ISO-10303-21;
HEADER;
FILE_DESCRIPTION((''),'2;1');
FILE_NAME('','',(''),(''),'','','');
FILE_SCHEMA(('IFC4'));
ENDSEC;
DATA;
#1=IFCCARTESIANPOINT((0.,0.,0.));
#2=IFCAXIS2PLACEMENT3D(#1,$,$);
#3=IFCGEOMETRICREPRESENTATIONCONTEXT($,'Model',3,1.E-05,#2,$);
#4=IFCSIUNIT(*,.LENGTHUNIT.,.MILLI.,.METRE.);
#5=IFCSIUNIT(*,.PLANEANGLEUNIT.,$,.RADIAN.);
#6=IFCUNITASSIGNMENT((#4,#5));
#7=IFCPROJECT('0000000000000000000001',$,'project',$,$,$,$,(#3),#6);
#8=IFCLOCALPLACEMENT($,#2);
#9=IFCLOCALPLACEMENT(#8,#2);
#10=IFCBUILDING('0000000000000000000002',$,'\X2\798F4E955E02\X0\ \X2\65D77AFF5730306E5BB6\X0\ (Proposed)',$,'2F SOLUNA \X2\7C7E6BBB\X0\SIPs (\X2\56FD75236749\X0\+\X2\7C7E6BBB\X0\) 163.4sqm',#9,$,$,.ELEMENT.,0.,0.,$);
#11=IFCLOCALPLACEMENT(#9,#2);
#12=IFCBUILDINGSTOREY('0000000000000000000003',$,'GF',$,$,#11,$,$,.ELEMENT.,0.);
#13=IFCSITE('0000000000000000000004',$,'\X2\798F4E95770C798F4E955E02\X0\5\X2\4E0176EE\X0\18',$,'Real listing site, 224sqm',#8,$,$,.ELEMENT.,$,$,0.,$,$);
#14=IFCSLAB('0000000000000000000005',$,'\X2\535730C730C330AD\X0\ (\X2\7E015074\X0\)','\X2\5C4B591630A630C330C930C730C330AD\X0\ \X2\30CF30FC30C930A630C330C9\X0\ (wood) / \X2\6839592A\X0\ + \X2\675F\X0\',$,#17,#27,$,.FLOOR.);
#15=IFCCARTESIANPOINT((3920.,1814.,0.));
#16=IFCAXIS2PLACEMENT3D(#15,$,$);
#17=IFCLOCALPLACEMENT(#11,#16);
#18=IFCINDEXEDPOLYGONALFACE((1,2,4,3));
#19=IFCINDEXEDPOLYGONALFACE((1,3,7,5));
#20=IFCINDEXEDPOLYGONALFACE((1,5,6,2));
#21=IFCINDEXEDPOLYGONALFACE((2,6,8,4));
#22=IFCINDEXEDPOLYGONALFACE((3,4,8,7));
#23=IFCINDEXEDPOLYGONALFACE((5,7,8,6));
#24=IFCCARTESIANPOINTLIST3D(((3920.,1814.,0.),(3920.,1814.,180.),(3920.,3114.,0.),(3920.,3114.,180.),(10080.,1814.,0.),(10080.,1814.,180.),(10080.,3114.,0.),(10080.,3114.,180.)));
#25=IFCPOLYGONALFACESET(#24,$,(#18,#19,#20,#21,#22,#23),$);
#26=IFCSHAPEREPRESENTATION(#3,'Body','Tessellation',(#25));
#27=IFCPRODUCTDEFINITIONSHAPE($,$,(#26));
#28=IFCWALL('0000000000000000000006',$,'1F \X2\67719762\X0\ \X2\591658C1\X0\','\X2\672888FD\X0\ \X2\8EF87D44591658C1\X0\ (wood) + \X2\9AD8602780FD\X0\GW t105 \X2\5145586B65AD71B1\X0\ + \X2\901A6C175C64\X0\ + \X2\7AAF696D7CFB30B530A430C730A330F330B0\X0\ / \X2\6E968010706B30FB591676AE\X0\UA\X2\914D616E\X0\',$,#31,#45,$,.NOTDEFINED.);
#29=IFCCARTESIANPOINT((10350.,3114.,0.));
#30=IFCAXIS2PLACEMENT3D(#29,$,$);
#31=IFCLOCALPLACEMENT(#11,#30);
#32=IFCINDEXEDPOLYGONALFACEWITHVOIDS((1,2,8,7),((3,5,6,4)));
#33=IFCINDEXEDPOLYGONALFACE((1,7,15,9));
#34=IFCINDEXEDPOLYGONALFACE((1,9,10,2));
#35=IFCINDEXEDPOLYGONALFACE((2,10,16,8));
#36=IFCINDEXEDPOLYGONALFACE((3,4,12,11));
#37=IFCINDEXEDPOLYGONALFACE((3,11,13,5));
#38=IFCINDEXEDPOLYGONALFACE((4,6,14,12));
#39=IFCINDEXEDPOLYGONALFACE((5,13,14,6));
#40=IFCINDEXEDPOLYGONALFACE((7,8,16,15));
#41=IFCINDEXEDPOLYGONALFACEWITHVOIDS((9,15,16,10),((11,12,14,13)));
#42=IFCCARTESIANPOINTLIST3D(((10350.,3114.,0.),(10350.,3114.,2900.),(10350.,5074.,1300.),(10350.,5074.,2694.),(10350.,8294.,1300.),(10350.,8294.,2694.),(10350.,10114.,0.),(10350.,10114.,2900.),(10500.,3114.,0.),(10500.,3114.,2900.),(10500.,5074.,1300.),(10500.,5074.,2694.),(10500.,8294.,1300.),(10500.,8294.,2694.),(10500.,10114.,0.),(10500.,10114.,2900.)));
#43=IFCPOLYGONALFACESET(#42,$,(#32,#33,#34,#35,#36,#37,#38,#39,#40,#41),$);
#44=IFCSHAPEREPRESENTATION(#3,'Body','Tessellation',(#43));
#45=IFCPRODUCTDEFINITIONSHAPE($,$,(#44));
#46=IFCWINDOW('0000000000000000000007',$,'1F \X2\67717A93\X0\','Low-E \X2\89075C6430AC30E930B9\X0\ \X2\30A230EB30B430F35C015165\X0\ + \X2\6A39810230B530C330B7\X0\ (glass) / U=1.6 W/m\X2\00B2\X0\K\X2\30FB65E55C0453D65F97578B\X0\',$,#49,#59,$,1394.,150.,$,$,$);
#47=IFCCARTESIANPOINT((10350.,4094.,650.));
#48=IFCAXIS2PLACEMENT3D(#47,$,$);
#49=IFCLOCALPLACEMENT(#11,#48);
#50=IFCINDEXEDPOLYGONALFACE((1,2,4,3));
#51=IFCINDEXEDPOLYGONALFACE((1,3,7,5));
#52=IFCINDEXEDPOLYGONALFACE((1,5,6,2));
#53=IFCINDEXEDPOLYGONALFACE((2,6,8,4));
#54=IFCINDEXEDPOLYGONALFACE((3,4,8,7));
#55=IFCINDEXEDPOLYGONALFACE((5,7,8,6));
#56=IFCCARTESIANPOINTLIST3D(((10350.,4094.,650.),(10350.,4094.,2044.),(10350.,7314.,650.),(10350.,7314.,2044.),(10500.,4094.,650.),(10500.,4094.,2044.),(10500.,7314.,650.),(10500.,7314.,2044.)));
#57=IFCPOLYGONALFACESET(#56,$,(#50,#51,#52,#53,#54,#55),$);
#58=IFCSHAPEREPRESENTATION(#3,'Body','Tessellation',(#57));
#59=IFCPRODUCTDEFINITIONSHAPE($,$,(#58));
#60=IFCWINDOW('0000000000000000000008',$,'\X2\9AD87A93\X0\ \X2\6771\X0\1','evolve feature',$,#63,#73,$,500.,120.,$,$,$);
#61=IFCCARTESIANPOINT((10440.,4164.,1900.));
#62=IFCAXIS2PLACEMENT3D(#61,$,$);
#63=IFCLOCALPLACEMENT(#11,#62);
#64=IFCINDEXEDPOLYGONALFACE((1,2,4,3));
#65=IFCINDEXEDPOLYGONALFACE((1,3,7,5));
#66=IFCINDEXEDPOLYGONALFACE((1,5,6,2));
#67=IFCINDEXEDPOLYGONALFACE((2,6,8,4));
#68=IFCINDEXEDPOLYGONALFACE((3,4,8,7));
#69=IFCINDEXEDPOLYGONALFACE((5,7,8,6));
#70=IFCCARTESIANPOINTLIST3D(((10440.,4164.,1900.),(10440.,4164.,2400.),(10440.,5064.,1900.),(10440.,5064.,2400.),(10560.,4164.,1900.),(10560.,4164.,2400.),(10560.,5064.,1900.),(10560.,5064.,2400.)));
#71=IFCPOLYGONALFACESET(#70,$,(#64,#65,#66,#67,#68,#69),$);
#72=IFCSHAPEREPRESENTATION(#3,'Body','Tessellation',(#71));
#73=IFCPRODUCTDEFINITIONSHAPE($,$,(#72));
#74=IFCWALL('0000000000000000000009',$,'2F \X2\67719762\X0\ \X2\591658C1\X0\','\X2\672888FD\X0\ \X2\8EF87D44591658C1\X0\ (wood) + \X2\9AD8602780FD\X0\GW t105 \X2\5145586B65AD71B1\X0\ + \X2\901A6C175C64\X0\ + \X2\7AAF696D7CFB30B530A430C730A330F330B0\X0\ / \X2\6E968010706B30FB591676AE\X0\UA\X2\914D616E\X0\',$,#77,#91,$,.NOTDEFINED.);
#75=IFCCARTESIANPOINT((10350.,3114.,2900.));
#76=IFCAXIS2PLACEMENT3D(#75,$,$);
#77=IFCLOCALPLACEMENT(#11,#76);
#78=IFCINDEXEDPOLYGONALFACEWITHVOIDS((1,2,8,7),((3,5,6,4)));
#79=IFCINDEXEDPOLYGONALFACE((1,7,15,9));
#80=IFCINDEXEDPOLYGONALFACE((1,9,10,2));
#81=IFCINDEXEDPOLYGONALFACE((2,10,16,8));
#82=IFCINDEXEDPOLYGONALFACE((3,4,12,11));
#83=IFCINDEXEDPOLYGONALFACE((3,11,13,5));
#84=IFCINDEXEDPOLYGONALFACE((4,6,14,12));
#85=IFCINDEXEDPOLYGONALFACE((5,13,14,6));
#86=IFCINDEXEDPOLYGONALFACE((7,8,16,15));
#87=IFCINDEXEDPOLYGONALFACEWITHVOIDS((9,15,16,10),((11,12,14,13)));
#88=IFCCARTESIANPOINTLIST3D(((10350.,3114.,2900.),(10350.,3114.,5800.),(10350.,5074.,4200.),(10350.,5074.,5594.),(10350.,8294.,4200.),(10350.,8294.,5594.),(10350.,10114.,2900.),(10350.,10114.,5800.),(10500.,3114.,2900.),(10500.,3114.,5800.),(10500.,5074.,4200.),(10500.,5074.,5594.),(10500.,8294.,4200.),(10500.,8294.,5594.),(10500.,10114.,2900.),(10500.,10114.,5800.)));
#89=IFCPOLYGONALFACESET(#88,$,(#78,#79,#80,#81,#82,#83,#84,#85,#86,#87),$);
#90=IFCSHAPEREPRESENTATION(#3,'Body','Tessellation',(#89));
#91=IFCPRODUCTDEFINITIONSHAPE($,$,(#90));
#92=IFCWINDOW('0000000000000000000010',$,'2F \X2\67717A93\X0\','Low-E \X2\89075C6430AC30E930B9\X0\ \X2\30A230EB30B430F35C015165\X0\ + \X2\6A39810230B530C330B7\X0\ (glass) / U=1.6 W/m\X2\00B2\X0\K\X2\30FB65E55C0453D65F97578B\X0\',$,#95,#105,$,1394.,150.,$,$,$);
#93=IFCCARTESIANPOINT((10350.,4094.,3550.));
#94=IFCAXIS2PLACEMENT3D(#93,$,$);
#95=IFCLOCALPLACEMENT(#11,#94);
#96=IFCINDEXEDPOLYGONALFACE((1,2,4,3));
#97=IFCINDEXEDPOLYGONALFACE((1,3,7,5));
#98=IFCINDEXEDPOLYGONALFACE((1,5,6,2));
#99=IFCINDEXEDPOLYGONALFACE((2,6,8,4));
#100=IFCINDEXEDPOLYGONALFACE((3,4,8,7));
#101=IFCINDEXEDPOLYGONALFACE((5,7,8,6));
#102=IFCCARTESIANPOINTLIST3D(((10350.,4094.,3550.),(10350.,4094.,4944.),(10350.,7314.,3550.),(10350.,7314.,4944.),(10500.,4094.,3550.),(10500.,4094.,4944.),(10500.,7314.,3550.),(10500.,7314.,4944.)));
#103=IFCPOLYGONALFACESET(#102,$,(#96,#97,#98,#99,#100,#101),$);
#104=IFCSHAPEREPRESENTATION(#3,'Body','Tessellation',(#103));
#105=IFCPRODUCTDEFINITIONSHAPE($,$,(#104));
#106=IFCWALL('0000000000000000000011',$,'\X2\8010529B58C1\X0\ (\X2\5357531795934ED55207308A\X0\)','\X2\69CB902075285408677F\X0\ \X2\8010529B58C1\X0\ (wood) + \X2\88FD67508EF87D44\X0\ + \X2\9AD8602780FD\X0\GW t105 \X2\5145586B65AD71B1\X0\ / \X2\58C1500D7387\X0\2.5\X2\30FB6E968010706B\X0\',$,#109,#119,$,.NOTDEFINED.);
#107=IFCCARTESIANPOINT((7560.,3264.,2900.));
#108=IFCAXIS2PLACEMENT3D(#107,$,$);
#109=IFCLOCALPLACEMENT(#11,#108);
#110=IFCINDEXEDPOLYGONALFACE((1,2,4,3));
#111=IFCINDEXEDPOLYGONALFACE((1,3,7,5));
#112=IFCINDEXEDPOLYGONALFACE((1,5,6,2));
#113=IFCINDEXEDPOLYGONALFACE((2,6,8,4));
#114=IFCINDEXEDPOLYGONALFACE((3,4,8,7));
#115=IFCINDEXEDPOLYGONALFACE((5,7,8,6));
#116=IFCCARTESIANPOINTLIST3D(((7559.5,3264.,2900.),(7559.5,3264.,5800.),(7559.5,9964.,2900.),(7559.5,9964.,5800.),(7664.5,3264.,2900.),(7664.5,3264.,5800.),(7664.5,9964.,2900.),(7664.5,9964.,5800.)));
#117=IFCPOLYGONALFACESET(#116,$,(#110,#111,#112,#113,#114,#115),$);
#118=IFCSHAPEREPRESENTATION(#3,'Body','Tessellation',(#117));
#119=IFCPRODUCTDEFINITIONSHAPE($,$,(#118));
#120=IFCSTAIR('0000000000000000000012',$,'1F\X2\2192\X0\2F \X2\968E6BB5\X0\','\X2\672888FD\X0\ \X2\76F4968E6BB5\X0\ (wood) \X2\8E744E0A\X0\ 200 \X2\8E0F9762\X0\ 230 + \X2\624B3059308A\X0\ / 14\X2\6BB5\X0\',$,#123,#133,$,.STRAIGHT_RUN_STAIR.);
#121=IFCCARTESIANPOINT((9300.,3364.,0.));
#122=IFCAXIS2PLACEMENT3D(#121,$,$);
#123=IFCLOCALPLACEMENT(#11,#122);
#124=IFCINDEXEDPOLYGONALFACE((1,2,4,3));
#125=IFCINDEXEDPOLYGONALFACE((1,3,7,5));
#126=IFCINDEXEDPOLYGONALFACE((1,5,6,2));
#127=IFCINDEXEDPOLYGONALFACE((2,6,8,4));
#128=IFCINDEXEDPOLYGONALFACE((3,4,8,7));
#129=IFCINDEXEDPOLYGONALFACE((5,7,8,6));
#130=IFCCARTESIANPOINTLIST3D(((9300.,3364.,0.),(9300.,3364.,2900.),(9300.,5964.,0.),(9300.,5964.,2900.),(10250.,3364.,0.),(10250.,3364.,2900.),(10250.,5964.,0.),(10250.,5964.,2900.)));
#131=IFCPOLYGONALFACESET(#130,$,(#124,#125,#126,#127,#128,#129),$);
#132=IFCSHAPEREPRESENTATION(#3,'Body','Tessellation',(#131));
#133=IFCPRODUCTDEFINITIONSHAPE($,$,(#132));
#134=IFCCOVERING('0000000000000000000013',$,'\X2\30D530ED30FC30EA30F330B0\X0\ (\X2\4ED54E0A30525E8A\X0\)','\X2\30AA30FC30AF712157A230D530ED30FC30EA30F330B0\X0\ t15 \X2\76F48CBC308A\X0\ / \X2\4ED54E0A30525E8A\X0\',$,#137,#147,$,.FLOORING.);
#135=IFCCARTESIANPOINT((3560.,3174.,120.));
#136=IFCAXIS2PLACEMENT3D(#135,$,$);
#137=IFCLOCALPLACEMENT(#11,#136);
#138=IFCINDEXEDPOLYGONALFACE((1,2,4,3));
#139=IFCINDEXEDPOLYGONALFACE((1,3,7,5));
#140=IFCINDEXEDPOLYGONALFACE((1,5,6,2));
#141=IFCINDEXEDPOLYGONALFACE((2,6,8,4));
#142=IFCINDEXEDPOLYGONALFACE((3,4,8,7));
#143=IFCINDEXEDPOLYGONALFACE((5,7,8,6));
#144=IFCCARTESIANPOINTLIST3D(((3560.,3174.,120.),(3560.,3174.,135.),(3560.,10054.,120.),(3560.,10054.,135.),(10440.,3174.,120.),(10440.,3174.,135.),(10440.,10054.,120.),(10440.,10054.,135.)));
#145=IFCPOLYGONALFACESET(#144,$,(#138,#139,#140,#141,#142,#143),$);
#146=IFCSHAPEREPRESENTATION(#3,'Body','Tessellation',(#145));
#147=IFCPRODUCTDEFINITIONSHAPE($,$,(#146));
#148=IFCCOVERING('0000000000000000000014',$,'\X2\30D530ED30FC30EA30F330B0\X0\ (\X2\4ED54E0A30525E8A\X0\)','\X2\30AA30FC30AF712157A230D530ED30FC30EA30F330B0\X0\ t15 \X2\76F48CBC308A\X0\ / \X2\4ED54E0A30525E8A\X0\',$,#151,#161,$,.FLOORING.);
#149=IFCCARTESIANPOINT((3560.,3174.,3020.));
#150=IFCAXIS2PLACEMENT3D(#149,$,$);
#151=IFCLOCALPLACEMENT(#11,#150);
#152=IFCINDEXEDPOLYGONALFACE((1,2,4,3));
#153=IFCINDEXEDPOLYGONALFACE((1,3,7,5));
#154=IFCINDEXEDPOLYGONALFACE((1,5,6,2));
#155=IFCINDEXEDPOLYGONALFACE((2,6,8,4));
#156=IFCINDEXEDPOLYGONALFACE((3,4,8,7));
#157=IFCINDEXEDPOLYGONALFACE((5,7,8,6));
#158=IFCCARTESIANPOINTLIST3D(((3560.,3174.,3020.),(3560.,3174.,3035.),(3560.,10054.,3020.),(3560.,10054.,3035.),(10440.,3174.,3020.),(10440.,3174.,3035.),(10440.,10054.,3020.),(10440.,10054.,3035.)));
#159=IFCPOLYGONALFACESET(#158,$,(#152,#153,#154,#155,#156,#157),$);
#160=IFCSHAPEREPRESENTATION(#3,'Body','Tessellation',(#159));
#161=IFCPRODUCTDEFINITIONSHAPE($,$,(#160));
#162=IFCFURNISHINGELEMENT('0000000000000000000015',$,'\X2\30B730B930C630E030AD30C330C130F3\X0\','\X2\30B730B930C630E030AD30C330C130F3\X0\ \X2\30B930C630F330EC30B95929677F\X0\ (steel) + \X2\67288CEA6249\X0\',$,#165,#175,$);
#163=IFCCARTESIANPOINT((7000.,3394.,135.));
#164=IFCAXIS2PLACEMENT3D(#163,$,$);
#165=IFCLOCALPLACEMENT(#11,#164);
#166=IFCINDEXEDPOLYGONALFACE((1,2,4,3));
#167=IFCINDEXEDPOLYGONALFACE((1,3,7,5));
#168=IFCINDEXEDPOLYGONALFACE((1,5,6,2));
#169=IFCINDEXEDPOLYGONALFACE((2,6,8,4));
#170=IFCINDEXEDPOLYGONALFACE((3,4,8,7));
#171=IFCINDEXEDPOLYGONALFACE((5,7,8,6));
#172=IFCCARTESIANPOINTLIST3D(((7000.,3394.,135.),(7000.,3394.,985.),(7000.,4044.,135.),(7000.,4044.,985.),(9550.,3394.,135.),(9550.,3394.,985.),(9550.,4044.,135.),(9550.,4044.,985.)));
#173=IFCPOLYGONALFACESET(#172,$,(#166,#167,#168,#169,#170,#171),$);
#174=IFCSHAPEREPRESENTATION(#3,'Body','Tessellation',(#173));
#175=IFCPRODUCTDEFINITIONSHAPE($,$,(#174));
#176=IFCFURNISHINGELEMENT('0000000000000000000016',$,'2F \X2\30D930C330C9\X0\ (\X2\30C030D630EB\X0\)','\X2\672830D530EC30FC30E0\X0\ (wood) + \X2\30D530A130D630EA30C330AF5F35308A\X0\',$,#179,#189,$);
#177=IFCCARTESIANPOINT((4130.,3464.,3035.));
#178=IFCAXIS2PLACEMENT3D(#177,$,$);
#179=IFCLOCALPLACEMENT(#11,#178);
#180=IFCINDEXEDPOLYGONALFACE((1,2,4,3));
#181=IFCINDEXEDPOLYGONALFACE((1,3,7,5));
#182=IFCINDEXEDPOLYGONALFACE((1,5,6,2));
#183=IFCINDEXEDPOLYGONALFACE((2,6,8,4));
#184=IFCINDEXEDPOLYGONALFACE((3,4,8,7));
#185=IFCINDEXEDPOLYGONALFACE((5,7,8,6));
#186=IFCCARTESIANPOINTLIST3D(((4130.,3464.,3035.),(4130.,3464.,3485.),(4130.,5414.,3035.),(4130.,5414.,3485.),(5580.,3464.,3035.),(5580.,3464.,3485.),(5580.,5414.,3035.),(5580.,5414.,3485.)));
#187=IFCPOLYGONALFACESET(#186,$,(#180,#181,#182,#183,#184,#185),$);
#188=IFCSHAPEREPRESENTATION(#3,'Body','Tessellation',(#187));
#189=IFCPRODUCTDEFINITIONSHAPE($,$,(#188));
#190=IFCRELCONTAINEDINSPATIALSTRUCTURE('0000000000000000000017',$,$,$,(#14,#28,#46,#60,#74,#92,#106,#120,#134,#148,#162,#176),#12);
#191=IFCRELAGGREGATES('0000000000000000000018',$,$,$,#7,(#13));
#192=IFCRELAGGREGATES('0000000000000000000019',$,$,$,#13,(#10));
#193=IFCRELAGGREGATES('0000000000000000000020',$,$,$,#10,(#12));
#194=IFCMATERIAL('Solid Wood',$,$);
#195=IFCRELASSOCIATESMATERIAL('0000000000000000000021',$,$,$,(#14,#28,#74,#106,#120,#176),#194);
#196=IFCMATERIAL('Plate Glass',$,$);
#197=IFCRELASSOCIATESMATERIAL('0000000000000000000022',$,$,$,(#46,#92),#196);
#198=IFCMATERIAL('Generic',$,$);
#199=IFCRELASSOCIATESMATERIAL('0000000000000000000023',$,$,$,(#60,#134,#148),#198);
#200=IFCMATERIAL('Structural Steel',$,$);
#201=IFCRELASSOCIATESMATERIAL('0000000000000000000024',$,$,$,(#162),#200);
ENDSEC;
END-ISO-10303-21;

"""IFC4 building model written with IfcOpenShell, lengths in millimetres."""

from ifc_helpers import new_model, si_unit, frame, frame_2d, origin, place, context, project, spatial, rectangle, extrude, material, element, fill, save


model = new_model("IFC4")

# Units and contexts
model_context = context("Model", 3, precision=1e-05, world=origin())
ifc_project = project(units=[si_unit("LENGTHUNIT", "METRE", prefix="MILLI"), si_unit("PLANEANGLEUNIT", "RADIAN")], contexts=[model_context])

# Site, building, storey
site_placement = place(None, origin())
site = spatial("IfcSite", under=ifc_project, at=site_placement, Name="福井県福井市5丁目18", ObjectType="Real listing site, 224sqm", CompositionType="ELEMENT", RefElevation=0.0)
building_placement = place(site_placement, origin())
building = spatial("IfcBuilding", under=site, at=building_placement, Name="福井市 旗竿地の家 (Proposed)", ObjectType="2F SOLUNA 籾殻SIPs (国産杉+籾殻) 163.4sqm", CompositionType="ELEMENT", ElevationOfRefHeight=0.0, ElevationOfTerrain=0.0)
storey_placement = place(building_placement, origin())
storey = spatial("IfcBuildingStorey", under=building, at=storey_placement, Name="GF", CompositionType="ELEMENT", Elevation=0.0)

# Slab
ifc_material_1 = material(Name="Solid Wood")
slab_placement = place(storey_placement, frame((3920.0, 1814.0, 0.0)))
element("IfcSlab", 1, at=slab_placement, inside=storey, material=ifc_material_1, Name="南デッキ (縁側)", Description="屋外ウッドデッキ ハードウッド (wood) / 根太 + 束", PredefinedType="FLOOR", context=model_context, shape_type="SweptSolid", body=[
    extrude(rectangle(XDim=6160.0, YDim=1300.0, at=frame_2d((3080.0, 650.0))), frame((3920.0, 1814.0, 0.0)), (0.0, 0.0, 1.0), 180.0),
])

# Wall, openings, windows
wall_1_placement = place(storey_placement, frame((10350.0, 3114.0, 0.0)))
wall_1 = element("IfcWall", 2, at=wall_1_placement, inside=storey, material=ifc_material_1, Name="1F 東面 外壁", Description="木製 軸組外壁 (wood) + 高性能GW t105 充填断熱 + 通気層 + 窯業系サイディング / 準耐火・外皮UA配慮", PredefinedType="NOTDEFINED", context=model_context, shape_type="SweptSolid", body=[
    extrude(rectangle(XDim=150.0, YDim=7000.0, at=frame_2d((75.0, 3500.0))), frame((10350.0, 3114.0, 0.0)), (0.0, 0.0, 1.0), 2900.0),
])
opening_1_placement = place(storey_placement, frame((10350.0, 4094.0, 650.0)))
opening_1 = element("IfcOpeningElement", 3, at=opening_1_placement, cuts=wall_1, PredefinedType="NOTDEFINED", context=model_context, shape_type="SweptSolid", body=[
    extrude(rectangle(XDim=150.0, YDim=3220.0, at=frame_2d((75.0, 1610.0))), frame((10350.0, 4094.0, 650.0)), (0.0, 0.0, 1.0), 1394.0),
])
opening_2_placement = place(storey_placement, frame((10440.0, 4164.0, 1900.0)))
opening_2 = element("IfcOpeningElement", 4, at=opening_2_placement, cuts=wall_1, PredefinedType="NOTDEFINED", context=model_context, shape_type="SweptSolid", body=[
    extrude(rectangle(XDim=120.0, YDim=900.0, at=frame_2d((60.0, 450.0))), frame((10440.0, 4164.0, 1900.0)), (0.0, 0.0, 1.0), 500.0),
])
ifc_material_2 = material(Name="Plate Glass")
window_1_placement = place(storey_placement, frame((10350.0, 4094.0, 650.0)))
window_1 = element("IfcWindow", 5, at=window_1_placement, inside=storey, material=ifc_material_2, Name="1F 東窓", Description="Low-E 複層ガラス アルゴン封入 + 樹脂サッシ (glass) / U=1.6 W/m²K・日射取得型", OverallHeight=1394.0, OverallWidth=150.0, context=model_context, shape_type="SweptSolid", body=[
    extrude(rectangle(XDim=150.0, YDim=3220.0, at=frame_2d((75.0, 1610.0))), frame((10350.0, 4094.0, 650.0)), (0.0, 0.0, 1.0), 1394.0),
])
fill(opening_1, window_1)
ifc_material_3 = material(Name="Generic")
window_2_placement = place(storey_placement, frame((10440.0, 4164.0, 1900.0)))
window_2 = element("IfcWindow", 6, at=window_2_placement, inside=storey, material=ifc_material_3, Name="高窓 東1", Description="evolve feature", OverallHeight=500.0, OverallWidth=120.0, context=model_context, shape_type="SweptSolid", body=[
    extrude(rectangle(XDim=120.0, YDim=900.0, at=frame_2d((60.0, 450.0))), frame((10440.0, 4164.0, 1900.0)), (0.0, 0.0, 1.0), 500.0),
])
fill(opening_2, window_2)

# Wall, opening, window
wall_2_placement = place(storey_placement, frame((10350.0, 3114.0, 2900.0)))
wall_2 = element("IfcWall", 7, at=wall_2_placement, inside=storey, material=ifc_material_1, Name="2F 東面 外壁", Description="木製 軸組外壁 (wood) + 高性能GW t105 充填断熱 + 通気層 + 窯業系サイディング / 準耐火・外皮UA配慮", PredefinedType="NOTDEFINED", context=model_context, shape_type="SweptSolid", body=[
    extrude(rectangle(XDim=150.0, YDim=7000.0, at=frame_2d((75.0, 3500.0))), frame((10350.0, 3114.0, 2900.0)), (0.0, 0.0, 1.0), 2900.0),
])
opening_3_placement = place(storey_placement, frame((10350.0, 4094.0, 3550.0)))
opening_3 = element("IfcOpeningElement", 8, at=opening_3_placement, cuts=wall_2, PredefinedType="NOTDEFINED", context=model_context, shape_type="SweptSolid", body=[
    extrude(rectangle(XDim=150.0, YDim=3220.0, at=frame_2d((75.0, 1610.0))), frame((10350.0, 4094.0, 3550.0)), (0.0, 0.0, 1.0), 1394.0),
])
window_3_placement = place(storey_placement, frame((10350.0, 4094.0, 3550.0)))
window_3 = element("IfcWindow", 9, at=window_3_placement, inside=storey, material=ifc_material_2, Name="2F 東窓", Description="Low-E 複層ガラス アルゴン封入 + 樹脂サッシ (glass) / U=1.6 W/m²K・日射取得型", OverallHeight=1394.0, OverallWidth=150.0, context=model_context, shape_type="SweptSolid", body=[
    extrude(rectangle(XDim=150.0, YDim=3220.0, at=frame_2d((75.0, 1610.0))), frame((10350.0, 4094.0, 3550.0)), (0.0, 0.0, 1.0), 1394.0),
])
fill(opening_3, window_3)

# Wall
wall_3_placement = place(storey_placement, frame((7560.0, 3264.0, 2900.0)))
element("IfcWall", 10, at=wall_3_placement, inside=storey, material=ifc_material_1, Name="耐力壁 (南北間仕切り)", Description="構造用合板 耐力壁 (wood) + 製材軸組 + 高性能GW t105 充填断熱 / 壁倍率2.5・準耐火", PredefinedType="NOTDEFINED", context=model_context, shape_type="SweptSolid", body=[
    extrude(rectangle(XDim=105.0, YDim=6700.0, at=frame_2d((52.0, 3350.0))), frame((7560.0, 3264.0, 2900.0)), (0.0, 0.0, 1.0), 2900.0),
])

# Stair
stair_placement = place(storey_placement, frame((9300.0, 3364.0, 0.0)))
element("IfcStair", 11, at=stair_placement, inside=storey, material=ifc_material_1, Name="1F→2F 階段", Description="木製 直階段 (wood) 蹴上 200 踏面 230 + 手すり / 14段", PredefinedType="STRAIGHT_RUN_STAIR", context=model_context, shape_type="SweptSolid", body=[
    extrude(rectangle(XDim=950.0, YDim=2600.0, at=frame_2d((475.0, 1300.0))), frame((9300.0, 3364.0, 0.0)), (0.0, 0.0, 1.0), 2900.0),
])

# Coverings
covering_1_placement = place(storey_placement, frame((3560.0, 3174.0, 120.0)))
element("IfcCovering", 12, at=covering_1_placement, inside=storey, material=ifc_material_3, Name="フローリング (仕上げ床)", Description="オーク無垢フローリング t15 直貼り / 仕上げ床", PredefinedType="FLOORING", context=model_context, shape_type="SweptSolid", body=[
    extrude(rectangle(XDim=6880.0, YDim=6880.0, at=frame_2d((3440.0, 3440.0))), frame((3560.0, 3174.0, 120.0)), (0.0, 0.0, 1.0), 15.0),
])
covering_2_placement = place(storey_placement, frame((3560.0, 3174.0, 3020.0)))
element("IfcCovering", 13, at=covering_2_placement, inside=storey, material=ifc_material_3, Name="フローリング (仕上げ床)", Description="オーク無垢フローリング t15 直貼り / 仕上げ床", PredefinedType="FLOORING", context=model_context, shape_type="SweptSolid", body=[
    extrude(rectangle(XDim=6880.0, YDim=6880.0, at=frame_2d((3440.0, 3440.0))), frame((3560.0, 3174.0, 3020.0)), (0.0, 0.0, 1.0), 15.0),
])

# Furnishing elements
ifc_material_4 = material(Name="Structural Steel")
furnishing_1_placement = place(storey_placement, frame((7000.0, 3394.0, 135.0)))
element("IfcFurnishingElement", 14, at=furnishing_1_placement, inside=storey, material=ifc_material_4, Name="システムキッチン", Description="システムキッチン ステンレス天板 (steel) + 木質扉", context=model_context, shape_type="SweptSolid", body=[
    extrude(rectangle(XDim=2550.0, YDim=650.0, at=frame_2d((1275.0, 325.0))), frame((7000.0, 3394.0, 135.0)), (0.0, 0.0, 1.0), 850.0),
])
furnishing_2_placement = place(storey_placement, frame((4130.0, 3464.0, 3035.0)))
element("IfcFurnishingElement", 15, at=furnishing_2_placement, inside=storey, material=ifc_material_1, Name="2F ベッド (ダブル)", Description="木フレーム (wood) + ファブリック張り", context=model_context, shape_type="SweptSolid", body=[
    extrude(rectangle(XDim=1450.0, YDim=1950.0, at=frame_2d((725.0, 975.0))), frame((4130.0, 3464.0, 3035.0)), (0.0, 0.0, 1.0), 450.0),
])

save(model, "model.ifc")
